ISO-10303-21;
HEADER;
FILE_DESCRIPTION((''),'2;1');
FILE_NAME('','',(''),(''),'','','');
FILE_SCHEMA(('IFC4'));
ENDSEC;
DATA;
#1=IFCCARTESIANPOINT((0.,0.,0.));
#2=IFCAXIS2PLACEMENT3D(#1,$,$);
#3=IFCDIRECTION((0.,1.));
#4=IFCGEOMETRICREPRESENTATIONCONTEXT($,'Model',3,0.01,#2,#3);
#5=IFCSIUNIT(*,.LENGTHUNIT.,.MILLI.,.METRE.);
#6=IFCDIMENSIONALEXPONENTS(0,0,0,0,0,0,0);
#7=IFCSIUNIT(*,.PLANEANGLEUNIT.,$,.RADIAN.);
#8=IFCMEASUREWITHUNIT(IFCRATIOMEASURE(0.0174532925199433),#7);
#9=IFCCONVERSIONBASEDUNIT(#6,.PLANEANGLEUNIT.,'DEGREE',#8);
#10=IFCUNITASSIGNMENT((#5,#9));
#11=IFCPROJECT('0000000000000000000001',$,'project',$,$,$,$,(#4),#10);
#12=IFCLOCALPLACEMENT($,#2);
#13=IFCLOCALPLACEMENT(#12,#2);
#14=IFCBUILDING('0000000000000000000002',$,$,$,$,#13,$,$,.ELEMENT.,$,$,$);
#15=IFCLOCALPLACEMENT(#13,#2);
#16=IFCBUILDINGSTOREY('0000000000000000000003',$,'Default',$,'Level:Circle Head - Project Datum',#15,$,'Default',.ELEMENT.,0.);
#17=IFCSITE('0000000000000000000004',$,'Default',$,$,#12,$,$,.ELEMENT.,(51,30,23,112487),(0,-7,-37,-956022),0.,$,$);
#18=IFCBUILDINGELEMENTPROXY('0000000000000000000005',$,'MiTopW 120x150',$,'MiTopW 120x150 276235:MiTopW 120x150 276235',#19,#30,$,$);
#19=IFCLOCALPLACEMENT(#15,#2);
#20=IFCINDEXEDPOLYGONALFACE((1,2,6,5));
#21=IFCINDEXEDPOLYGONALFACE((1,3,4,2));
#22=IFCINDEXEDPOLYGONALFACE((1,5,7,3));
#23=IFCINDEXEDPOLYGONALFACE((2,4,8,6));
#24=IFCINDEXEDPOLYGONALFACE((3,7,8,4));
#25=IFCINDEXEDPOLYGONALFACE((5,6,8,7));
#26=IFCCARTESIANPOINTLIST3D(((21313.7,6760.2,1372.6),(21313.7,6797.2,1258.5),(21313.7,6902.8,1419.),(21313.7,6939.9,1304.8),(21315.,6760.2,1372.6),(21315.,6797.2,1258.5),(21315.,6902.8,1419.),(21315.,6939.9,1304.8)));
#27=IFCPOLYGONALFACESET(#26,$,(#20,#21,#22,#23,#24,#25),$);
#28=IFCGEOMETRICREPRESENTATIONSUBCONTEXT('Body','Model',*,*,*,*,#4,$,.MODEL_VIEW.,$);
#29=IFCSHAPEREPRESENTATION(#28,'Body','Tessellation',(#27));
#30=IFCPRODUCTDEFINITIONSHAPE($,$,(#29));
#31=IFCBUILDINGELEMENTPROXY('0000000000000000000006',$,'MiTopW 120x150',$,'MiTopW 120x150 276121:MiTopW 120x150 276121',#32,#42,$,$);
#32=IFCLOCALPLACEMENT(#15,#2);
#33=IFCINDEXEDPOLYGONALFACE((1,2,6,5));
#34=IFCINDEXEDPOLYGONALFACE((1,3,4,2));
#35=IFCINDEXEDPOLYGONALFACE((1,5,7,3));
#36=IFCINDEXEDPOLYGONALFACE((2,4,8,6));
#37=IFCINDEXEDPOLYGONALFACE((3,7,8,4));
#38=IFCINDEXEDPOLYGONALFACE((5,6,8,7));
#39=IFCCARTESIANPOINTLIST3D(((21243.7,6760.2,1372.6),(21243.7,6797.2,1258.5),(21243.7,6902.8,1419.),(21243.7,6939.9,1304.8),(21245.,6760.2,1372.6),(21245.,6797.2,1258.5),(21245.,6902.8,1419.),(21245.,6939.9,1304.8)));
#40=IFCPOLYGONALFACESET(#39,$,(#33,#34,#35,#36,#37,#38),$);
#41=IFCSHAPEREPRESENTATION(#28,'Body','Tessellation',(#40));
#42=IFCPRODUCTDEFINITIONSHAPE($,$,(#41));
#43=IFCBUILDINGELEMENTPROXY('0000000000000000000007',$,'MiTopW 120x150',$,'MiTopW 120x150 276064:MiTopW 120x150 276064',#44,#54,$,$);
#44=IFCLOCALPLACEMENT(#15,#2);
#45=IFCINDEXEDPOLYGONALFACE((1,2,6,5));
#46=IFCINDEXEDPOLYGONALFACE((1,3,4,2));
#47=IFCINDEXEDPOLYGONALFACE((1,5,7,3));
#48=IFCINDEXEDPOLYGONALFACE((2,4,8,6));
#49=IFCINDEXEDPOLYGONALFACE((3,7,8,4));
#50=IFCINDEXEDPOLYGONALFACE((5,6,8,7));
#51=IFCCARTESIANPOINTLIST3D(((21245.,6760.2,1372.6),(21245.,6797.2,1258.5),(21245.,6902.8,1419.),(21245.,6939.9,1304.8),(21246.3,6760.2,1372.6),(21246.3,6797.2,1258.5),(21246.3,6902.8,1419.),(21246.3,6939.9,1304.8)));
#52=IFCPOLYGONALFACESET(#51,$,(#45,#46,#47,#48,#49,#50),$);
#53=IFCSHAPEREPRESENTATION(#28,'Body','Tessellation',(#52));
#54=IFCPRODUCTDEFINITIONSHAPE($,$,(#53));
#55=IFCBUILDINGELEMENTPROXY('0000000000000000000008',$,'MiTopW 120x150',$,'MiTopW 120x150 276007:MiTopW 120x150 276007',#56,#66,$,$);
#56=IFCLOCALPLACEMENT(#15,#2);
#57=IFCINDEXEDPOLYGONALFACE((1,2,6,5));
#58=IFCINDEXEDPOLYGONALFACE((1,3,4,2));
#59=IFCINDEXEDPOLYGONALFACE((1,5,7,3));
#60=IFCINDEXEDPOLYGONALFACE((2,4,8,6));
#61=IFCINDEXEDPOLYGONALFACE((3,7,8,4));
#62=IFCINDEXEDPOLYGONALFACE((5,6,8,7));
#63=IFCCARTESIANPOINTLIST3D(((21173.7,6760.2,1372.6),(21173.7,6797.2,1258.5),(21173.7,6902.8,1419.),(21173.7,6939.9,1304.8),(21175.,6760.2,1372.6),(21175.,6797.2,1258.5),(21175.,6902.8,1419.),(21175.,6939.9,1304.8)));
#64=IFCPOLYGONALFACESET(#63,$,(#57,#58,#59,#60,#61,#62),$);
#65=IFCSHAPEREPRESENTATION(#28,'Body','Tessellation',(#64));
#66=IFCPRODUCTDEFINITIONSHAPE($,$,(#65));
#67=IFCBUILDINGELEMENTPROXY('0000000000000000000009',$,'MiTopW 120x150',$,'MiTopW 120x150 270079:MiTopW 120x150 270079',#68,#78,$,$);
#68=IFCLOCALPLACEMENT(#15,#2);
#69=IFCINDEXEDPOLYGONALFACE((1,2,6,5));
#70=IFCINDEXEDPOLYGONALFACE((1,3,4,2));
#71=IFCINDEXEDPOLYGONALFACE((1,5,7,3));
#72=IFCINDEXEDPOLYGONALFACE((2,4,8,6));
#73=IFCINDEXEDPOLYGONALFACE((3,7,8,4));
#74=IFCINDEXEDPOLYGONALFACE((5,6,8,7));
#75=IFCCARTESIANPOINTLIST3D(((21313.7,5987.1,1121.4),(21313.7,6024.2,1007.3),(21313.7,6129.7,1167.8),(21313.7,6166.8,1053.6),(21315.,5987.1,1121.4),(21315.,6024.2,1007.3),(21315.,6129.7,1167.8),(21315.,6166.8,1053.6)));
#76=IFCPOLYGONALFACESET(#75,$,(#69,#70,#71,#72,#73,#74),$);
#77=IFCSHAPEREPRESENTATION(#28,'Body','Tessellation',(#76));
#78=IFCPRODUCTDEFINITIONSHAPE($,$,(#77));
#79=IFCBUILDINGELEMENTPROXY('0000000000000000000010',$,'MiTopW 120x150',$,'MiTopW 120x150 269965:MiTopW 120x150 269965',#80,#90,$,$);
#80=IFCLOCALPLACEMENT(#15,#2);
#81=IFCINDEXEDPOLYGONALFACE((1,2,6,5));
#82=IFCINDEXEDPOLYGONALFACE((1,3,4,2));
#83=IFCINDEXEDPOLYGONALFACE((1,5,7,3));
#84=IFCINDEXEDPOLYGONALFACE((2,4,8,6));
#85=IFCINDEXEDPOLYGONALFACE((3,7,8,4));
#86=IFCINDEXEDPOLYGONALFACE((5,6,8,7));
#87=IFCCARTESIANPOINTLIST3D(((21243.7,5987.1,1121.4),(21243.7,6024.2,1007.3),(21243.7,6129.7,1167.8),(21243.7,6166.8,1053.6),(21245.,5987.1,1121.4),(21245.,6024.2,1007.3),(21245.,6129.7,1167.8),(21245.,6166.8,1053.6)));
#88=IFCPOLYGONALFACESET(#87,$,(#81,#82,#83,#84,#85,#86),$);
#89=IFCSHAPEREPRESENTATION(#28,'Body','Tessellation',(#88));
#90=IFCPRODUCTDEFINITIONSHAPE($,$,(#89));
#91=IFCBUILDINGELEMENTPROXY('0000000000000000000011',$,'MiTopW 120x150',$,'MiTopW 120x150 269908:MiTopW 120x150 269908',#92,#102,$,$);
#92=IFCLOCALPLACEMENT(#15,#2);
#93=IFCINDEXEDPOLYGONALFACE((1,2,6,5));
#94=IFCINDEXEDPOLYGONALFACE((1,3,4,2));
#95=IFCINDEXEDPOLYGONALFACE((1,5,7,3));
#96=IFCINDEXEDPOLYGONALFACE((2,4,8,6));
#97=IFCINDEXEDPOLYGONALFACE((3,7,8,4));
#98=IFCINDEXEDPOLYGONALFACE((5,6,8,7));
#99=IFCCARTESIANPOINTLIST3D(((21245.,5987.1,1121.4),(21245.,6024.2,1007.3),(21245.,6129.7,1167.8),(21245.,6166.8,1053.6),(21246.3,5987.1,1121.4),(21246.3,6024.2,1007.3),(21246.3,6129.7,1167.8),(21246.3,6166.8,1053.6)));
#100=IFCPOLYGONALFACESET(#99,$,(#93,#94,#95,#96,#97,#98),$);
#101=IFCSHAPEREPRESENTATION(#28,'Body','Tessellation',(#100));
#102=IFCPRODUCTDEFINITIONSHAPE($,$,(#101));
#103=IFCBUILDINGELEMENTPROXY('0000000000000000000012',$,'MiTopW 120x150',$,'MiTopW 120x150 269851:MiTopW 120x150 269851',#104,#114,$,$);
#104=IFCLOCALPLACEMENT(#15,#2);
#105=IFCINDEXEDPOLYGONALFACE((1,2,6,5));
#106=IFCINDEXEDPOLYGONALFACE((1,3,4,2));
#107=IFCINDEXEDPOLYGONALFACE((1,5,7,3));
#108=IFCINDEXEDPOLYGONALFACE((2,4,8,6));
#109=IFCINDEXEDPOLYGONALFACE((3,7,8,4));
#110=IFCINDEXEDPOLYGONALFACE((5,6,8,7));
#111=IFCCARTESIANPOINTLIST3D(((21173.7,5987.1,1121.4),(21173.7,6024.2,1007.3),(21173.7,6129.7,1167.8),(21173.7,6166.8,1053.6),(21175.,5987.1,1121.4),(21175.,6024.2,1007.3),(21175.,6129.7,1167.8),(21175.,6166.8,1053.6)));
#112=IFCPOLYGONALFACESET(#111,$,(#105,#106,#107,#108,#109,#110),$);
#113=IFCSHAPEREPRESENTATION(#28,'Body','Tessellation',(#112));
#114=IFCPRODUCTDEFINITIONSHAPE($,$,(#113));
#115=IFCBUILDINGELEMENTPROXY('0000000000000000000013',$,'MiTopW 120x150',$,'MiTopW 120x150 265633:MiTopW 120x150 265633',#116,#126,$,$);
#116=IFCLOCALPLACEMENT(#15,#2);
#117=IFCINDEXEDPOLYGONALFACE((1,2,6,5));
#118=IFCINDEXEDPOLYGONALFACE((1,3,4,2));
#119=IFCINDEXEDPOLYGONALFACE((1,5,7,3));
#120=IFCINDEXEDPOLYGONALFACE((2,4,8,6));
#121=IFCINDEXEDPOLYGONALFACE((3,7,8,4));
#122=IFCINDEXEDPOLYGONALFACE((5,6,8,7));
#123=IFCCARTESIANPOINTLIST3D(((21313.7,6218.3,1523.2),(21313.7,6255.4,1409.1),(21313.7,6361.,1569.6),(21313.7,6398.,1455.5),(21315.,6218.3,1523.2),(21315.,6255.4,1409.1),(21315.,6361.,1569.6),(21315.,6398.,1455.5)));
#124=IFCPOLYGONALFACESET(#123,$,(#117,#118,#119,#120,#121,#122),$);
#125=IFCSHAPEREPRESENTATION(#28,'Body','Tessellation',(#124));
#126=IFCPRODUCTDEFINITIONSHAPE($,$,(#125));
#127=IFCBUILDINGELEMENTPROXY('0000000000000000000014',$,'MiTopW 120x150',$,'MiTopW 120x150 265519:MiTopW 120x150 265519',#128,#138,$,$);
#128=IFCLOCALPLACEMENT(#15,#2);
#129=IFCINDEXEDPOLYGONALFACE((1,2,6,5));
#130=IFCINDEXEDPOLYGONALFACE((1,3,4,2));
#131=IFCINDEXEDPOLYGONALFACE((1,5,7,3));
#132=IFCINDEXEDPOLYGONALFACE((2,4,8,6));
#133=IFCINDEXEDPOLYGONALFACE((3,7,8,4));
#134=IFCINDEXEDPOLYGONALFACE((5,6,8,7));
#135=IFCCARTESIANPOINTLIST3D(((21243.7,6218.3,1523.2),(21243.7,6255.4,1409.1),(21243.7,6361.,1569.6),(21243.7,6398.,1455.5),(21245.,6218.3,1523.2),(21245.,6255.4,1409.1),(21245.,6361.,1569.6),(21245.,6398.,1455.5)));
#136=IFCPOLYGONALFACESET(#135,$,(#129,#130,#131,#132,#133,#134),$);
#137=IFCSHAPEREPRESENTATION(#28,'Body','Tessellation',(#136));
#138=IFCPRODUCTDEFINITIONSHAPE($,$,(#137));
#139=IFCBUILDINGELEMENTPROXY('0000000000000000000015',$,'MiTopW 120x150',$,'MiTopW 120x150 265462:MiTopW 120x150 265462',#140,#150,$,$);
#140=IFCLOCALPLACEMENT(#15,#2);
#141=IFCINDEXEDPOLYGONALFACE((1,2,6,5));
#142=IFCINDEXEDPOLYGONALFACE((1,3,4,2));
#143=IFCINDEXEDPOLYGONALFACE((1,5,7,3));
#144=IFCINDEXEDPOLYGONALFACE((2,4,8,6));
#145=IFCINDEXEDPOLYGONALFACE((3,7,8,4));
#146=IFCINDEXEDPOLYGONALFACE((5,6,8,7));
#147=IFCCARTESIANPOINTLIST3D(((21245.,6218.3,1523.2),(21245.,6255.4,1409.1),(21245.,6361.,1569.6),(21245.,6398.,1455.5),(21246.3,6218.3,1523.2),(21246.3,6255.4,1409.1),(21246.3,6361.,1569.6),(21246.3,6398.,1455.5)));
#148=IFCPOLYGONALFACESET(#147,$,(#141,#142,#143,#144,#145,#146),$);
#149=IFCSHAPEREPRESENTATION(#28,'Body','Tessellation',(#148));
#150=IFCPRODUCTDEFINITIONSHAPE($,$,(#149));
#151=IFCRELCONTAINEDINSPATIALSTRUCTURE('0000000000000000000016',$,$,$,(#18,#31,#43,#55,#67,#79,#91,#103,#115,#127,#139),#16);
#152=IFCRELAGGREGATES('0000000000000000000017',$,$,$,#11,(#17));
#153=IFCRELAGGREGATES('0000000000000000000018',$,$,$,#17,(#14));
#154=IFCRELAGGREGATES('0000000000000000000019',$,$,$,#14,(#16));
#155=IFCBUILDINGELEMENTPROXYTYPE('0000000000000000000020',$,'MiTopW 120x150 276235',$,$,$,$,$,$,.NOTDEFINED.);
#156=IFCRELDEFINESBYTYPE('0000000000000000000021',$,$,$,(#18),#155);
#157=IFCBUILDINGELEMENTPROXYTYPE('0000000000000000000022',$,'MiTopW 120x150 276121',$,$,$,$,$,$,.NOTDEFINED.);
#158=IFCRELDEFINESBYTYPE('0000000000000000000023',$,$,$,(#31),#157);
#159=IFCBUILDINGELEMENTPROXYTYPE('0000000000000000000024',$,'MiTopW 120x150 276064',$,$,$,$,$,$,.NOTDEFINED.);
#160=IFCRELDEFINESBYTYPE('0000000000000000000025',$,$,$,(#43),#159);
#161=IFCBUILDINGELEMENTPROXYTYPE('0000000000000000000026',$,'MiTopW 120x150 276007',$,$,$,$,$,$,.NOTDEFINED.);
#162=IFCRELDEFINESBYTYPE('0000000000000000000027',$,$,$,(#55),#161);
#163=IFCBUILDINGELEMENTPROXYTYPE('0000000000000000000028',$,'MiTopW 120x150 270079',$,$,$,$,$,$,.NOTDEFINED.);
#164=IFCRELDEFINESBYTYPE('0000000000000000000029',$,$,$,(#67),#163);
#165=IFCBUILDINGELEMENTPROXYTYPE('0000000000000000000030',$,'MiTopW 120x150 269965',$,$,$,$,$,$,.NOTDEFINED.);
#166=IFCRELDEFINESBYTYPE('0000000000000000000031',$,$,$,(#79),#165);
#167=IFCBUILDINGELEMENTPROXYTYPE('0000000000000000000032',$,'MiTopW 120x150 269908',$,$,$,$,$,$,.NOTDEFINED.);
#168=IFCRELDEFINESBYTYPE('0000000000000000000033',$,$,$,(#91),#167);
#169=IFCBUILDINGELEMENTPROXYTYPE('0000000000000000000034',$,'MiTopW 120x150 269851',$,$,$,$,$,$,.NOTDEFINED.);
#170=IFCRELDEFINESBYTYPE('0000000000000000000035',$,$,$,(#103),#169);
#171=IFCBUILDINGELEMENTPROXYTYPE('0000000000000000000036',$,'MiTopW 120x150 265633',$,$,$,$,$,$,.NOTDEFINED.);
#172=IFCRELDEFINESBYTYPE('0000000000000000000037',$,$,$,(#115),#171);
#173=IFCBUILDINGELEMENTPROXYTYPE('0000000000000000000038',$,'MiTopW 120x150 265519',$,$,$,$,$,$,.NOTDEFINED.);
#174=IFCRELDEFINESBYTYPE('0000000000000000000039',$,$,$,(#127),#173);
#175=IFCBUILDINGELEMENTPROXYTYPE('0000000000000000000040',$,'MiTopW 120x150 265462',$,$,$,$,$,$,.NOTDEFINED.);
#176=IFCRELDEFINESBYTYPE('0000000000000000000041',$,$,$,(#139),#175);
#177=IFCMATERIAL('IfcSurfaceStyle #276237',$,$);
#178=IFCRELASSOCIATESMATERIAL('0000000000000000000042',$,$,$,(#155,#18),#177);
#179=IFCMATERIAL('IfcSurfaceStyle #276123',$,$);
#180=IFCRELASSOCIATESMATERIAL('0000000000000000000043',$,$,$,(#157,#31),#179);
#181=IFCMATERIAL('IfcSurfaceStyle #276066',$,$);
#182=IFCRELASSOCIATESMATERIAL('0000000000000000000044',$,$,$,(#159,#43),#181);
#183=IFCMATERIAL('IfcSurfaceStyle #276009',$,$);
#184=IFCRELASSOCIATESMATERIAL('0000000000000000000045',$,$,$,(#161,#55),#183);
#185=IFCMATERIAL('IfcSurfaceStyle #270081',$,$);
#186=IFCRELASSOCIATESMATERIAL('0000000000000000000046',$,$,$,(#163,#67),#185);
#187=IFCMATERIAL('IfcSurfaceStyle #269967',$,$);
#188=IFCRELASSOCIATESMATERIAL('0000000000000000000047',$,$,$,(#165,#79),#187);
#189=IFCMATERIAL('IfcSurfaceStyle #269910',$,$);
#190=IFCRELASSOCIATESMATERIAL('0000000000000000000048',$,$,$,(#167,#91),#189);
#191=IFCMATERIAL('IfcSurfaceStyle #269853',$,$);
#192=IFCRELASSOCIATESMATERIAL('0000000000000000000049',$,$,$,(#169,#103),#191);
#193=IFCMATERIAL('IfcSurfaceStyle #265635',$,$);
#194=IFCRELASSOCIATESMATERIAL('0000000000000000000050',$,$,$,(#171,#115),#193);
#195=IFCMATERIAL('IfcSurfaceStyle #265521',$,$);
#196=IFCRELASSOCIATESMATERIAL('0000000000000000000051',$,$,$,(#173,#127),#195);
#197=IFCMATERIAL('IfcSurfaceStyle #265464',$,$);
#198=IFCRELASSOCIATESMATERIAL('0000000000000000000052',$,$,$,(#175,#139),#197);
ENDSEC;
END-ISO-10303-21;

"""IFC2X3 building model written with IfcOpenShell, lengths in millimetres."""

from ifc_helpers import new_model, entity, si_unit, converted_unit, direction, frame, origin, place, context, subcontext, project, spatial, polyline, outline, extrude, source, transform, mapped, material, type_object, type_shapes, element, save


model = new_model("IFC2X3")

# Units and contexts
model_context = context("Model", 3, precision=0.01, world=origin(), true_north=direction((0.0, 1.0)))
body_context = subcontext(model_context, "Body", "Model", "MODEL_VIEW")
ifc_project = project(units=[si_unit("LENGTHUNIT", "METRE", prefix="MILLI"), converted_unit("PLANEANGLEUNIT", "DEGREE", entity("IfcRatioMeasure", 0.0174532925199433), si_unit("PLANEANGLEUNIT", "RADIAN"), dimensions=[0, 0, 0, 0, 0, 0, 0])], contexts=[model_context])

# Site, building, storey
site_placement = place(None, origin())
site = spatial("IfcSite", under=ifc_project, at=site_placement, Name="Default", CompositionType="ELEMENT", RefLatitude=(51, 30, 23, 112487), RefLongitude=(0, -7, -37, -956022), RefElevation=0.0)
building_placement = place(site_placement, origin())
building = spatial("IfcBuilding", under=site, at=building_placement, CompositionType="ELEMENT")
storey_placement = place(building_placement, origin())
storey = spatial("IfcBuildingStorey", under=building, at=storey_placement, Name="Default", ObjectType="Level:Circle Head - Project Datum", LongName="Default", CompositionType="ELEMENT", Elevation=0.0)

# Building element proxies
ifc_material_1 = material(Name="IfcSurfaceStyle #276237")
building_element_proxy_type_1 = type_object("IfcBuildingElementProxyType", Name="MiTopW 120x150 276235", PredefinedType="NOTDEFINED", material=ifc_material_1)
shared_shape_1 = source(origin(), body_context, "Body", "SweptSolid", [
    extrude(outline(polyline([(-75.0, -60.0), (75.0, -60.0), (75.0, 60.0), (-75.0, 60.0), (-75.0, -60.0)])), frame((75.0, 60.0, 0.0), z_axis=(0.0, 0.0, 1.0), x_axis=(-1.0, 0.0, 0.0)), (0.0, 0.0, 1.0), 1.3),
])
type_shapes(building_element_proxy_type_1, [shared_shape_1])
proxy_1_placement = place(building_placement, frame((21315.0, 6760.2, 1372.6), z_axis=(-1.0, 0.0, 0.0), x_axis=(0.0, 0.951057, 0.309017)))
element("IfcBuildingElementProxy", 1, at=proxy_1_placement, inside=storey, type_object=building_element_proxy_type_1, material=ifc_material_1, Name="MiTopW 120x150", ObjectType="MiTopW 120x150 276235:MiTopW 120x150 276235", context=body_context, shape_type="MappedRepresentation", body=[
    mapped(shared_shape_1, transform((0.0, 0.0, 0.0), scale=1.0)),
])
ifc_material_2 = material(Name="IfcSurfaceStyle #276123")
building_element_proxy_type_2 = type_object("IfcBuildingElementProxyType", Name="MiTopW 120x150 276121", PredefinedType="NOTDEFINED", material=ifc_material_2)
shared_shape_2 = source(origin(), body_context, "Body", "SweptSolid", [
    extrude(outline(polyline([(-75.0, -60.0), (75.0, -60.0), (75.0, 60.0), (-75.0, 60.0), (-75.0, -60.0)])), frame((75.0, 60.0, 0.0), z_axis=(0.0, 0.0, 1.0), x_axis=(-1.0, 0.0, 0.0)), (0.0, 0.0, 1.0), 1.3),
])
type_shapes(building_element_proxy_type_2, [shared_shape_2])
proxy_2_placement = place(building_placement, frame((21245.0, 6760.2, 1372.6), z_axis=(-1.0, 0.0, 0.0), x_axis=(0.0, 0.951057, 0.309017)))
element("IfcBuildingElementProxy", 2, at=proxy_2_placement, inside=storey, type_object=building_element_proxy_type_2, material=ifc_material_2, Name="MiTopW 120x150", ObjectType="MiTopW 120x150 276121:MiTopW 120x150 276121", context=body_context, shape_type="MappedRepresentation", body=[
    mapped(shared_shape_2, transform((0.0, 0.0, 0.0), scale=1.0)),
])
ifc_material_3 = material(Name="IfcSurfaceStyle #276066")
building_element_proxy_type_3 = type_object("IfcBuildingElementProxyType", Name="MiTopW 120x150 276064", PredefinedType="NOTDEFINED", material=ifc_material_3)
shared_shape_3 = source(origin(), body_context, "Body", "SweptSolid", [
    extrude(outline(polyline([(-75.0, -60.0), (75.0, -60.0), (75.0, 60.0), (-75.0, 60.0), (-75.0, -60.0)])), frame((75.0, 60.0, 0.0), z_axis=(0.0, 0.0, 1.0), x_axis=(-1.0, 0.0, 0.0)), (0.0, 0.0, 1.0), 1.3),
])
type_shapes(building_element_proxy_type_3, [shared_shape_3])
proxy_3_placement = place(building_placement, frame((21246.3, 6760.2, 1372.6), z_axis=(-1.0, 0.0, 0.0), x_axis=(0.0, 0.951057, 0.309017)))
element("IfcBuildingElementProxy", 3, at=proxy_3_placement, inside=storey, type_object=building_element_proxy_type_3, material=ifc_material_3, Name="MiTopW 120x150", ObjectType="MiTopW 120x150 276064:MiTopW 120x150 276064", context=body_context, shape_type="MappedRepresentation", body=[
    mapped(shared_shape_3, transform((0.0, 0.0, 0.0), scale=1.0)),
])
ifc_material_4 = material(Name="IfcSurfaceStyle #276009")
building_element_proxy_type_4 = type_object("IfcBuildingElementProxyType", Name="MiTopW 120x150 276007", PredefinedType="NOTDEFINED", material=ifc_material_4)
shared_shape_4 = source(origin(), body_context, "Body", "SweptSolid", [
    extrude(outline(polyline([(-75.0, -60.0), (75.0, -60.0), (75.0, 60.0), (-75.0, 60.0), (-75.0, -60.0)])), frame((75.0, 60.0, 0.0), z_axis=(0.0, 0.0, 1.0), x_axis=(-1.0, 0.0, 0.0)), (0.0, 0.0, 1.0), 1.3),
])
type_shapes(building_element_proxy_type_4, [shared_shape_4])
proxy_4_placement = place(building_placement, frame((21175.0, 6760.2, 1372.6), z_axis=(-1.0, 0.0, 0.0), x_axis=(0.0, 0.951057, 0.309017)))
element("IfcBuildingElementProxy", 4, at=proxy_4_placement, inside=storey, type_object=building_element_proxy_type_4, material=ifc_material_4, Name="MiTopW 120x150", ObjectType="MiTopW 120x150 276007:MiTopW 120x150 276007", context=body_context, shape_type="MappedRepresentation", body=[
    mapped(shared_shape_4, transform((0.0, 0.0, 0.0), scale=1.0)),
])
ifc_material_5 = material(Name="IfcSurfaceStyle #270081")
building_element_proxy_type_5 = type_object("IfcBuildingElementProxyType", Name="MiTopW 120x150 270079", PredefinedType="NOTDEFINED", material=ifc_material_5)
shared_shape_5 = source(origin(), body_context, "Body", "SweptSolid", [
    extrude(outline(polyline([(-75.0, -60.0), (75.0, -60.0), (75.0, 60.0), (-75.0, 60.0), (-75.0, -60.0)])), frame((75.0, 60.0, 0.0), z_axis=(0.0, 0.0, 1.0), x_axis=(-1.0, 0.0, 0.0)), (0.0, 0.0, 1.0), 1.3),
])
type_shapes(building_element_proxy_type_5, [shared_shape_5])
proxy_5_placement = place(building_placement, frame((21315.0, 5987.1, 1121.4), z_axis=(-1.0, 0.0, 0.0), x_axis=(0.0, 0.951057, 0.309017)))
element("IfcBuildingElementProxy", 5, at=proxy_5_placement, inside=storey, type_object=building_element_proxy_type_5, material=ifc_material_5, Name="MiTopW 120x150", ObjectType="MiTopW 120x150 270079:MiTopW 120x150 270079", context=body_context, shape_type="MappedRepresentation", body=[
    mapped(shared_shape_5, transform((0.0, 0.0, 0.0), scale=1.0)),
])
ifc_material_6 = material(Name="IfcSurfaceStyle #269967")
building_element_proxy_type_6 = type_object("IfcBuildingElementProxyType", Name="MiTopW 120x150 269965", PredefinedType="NOTDEFINED", material=ifc_material_6)
shared_shape_6 = source(origin(), body_context, "Body", "SweptSolid", [
    extrude(outline(polyline([(-75.0, -60.0), (75.0, -60.0), (75.0, 60.0), (-75.0, 60.0), (-75.0, -60.0)])), frame((75.0, 60.0, 0.0), z_axis=(0.0, 0.0, 1.0), x_axis=(-1.0, 0.0, 0.0)), (0.0, 0.0, 1.0), 1.3),
])
type_shapes(building_element_proxy_type_6, [shared_shape_6])
proxy_6_placement = place(building_placement, frame((21245.0, 5987.1, 1121.4), z_axis=(-1.0, 0.0, 0.0), x_axis=(0.0, 0.951057, 0.309017)))
element("IfcBuildingElementProxy", 6, at=proxy_6_placement, inside=storey, type_object=building_element_proxy_type_6, material=ifc_material_6, Name="MiTopW 120x150", ObjectType="MiTopW 120x150 269965:MiTopW 120x150 269965", context=body_context, shape_type="MappedRepresentation", body=[
    mapped(shared_shape_6, transform((0.0, 0.0, 0.0), scale=1.0)),
])
ifc_material_7 = material(Name="IfcSurfaceStyle #269910")
building_element_proxy_type_7 = type_object("IfcBuildingElementProxyType", Name="MiTopW 120x150 269908", PredefinedType="NOTDEFINED", material=ifc_material_7)
shared_shape_7 = source(origin(), body_context, "Body", "SweptSolid", [
    extrude(outline(polyline([(-75.0, -60.0), (75.0, -60.0), (75.0, 60.0), (-75.0, 60.0), (-75.0, -60.0)])), frame((75.0, 60.0, 0.0), z_axis=(0.0, 0.0, 1.0), x_axis=(-1.0, 0.0, 0.0)), (0.0, 0.0, 1.0), 1.3),
])
type_shapes(building_element_proxy_type_7, [shared_shape_7])
proxy_7_placement = place(building_placement, frame((21246.3, 5987.1, 1121.4), z_axis=(-1.0, 0.0, 0.0), x_axis=(0.0, 0.951057, 0.309017)))
element("IfcBuildingElementProxy", 7, at=proxy_7_placement, inside=storey, type_object=building_element_proxy_type_7, material=ifc_material_7, Name="MiTopW 120x150", ObjectType="MiTopW 120x150 269908:MiTopW 120x150 269908", context=body_context, shape_type="MappedRepresentation", body=[
    mapped(shared_shape_7, transform((0.0, 0.0, 0.0), scale=1.0)),
])
ifc_material_8 = material(Name="IfcSurfaceStyle #269853")
building_element_proxy_type_8 = type_object("IfcBuildingElementProxyType", Name="MiTopW 120x150 269851", PredefinedType="NOTDEFINED", material=ifc_material_8)
shared_shape_8 = source(origin(), body_context, "Body", "SweptSolid", [
    extrude(outline(polyline([(-75.0, -60.0), (75.0, -60.0), (75.0, 60.0), (-75.0, 60.0), (-75.0, -60.0)])), frame((75.0, 60.0, 0.0), z_axis=(0.0, 0.0, 1.0), x_axis=(-1.0, 0.0, 0.0)), (0.0, 0.0, 1.0), 1.3),
])
type_shapes(building_element_proxy_type_8, [shared_shape_8])
proxy_8_placement = place(building_placement, frame((21175.0, 5987.1, 1121.4), z_axis=(-1.0, 0.0, 0.0), x_axis=(0.0, 0.951057, 0.309017)))
element("IfcBuildingElementProxy", 8, at=proxy_8_placement, inside=storey, type_object=building_element_proxy_type_8, material=ifc_material_8, Name="MiTopW 120x150", ObjectType="MiTopW 120x150 269851:MiTopW 120x150 269851", context=body_context, shape_type="MappedRepresentation", body=[
    mapped(shared_shape_8, transform((0.0, 0.0, 0.0), scale=1.0)),
])
ifc_material_9 = material(Name="IfcSurfaceStyle #265635")
building_element_proxy_type_9 = type_object("IfcBuildingElementProxyType", Name="MiTopW 120x150 265633", PredefinedType="NOTDEFINED", material=ifc_material_9)
shared_shape_9 = source(origin(), body_context, "Body", "SweptSolid", [
    extrude(outline(polyline([(-75.0, -60.0), (75.0, -60.0), (75.0, 60.0), (-75.0, 60.0), (-75.0, -60.0)])), frame((75.0, 60.0, 0.0), z_axis=(0.0, 0.0, 1.0), x_axis=(-1.0, 0.0, 0.0)), (0.0, 0.0, 1.0), 1.3),
])
type_shapes(building_element_proxy_type_9, [shared_shape_9])
proxy_9_placement = place(building_placement, frame((21315.0, 6218.3, 1523.2), z_axis=(-1.0, 0.0, 0.0), x_axis=(0.0, 0.951057, 0.309017)))
element("IfcBuildingElementProxy", 9, at=proxy_9_placement, inside=storey, type_object=building_element_proxy_type_9, material=ifc_material_9, Name="MiTopW 120x150", ObjectType="MiTopW 120x150 265633:MiTopW 120x150 265633", context=body_context, shape_type="MappedRepresentation", body=[
    mapped(shared_shape_9, transform((0.0, 0.0, 0.0), scale=1.0)),
])
ifc_material_10 = material(Name="IfcSurfaceStyle #265521")
building_element_proxy_type_10 = type_object("IfcBuildingElementProxyType", Name="MiTopW 120x150 265519", PredefinedType="NOTDEFINED", material=ifc_material_10)
shared_shape_10 = source(origin(), body_context, "Body", "SweptSolid", [
    extrude(outline(polyline([(-75.0, -60.0), (75.0, -60.0), (75.0, 60.0), (-75.0, 60.0), (-75.0, -60.0)])), frame((75.0, 60.0, 0.0), z_axis=(0.0, 0.0, 1.0), x_axis=(-1.0, 0.0, 0.0)), (0.0, 0.0, 1.0), 1.3),
])
type_shapes(building_element_proxy_type_10, [shared_shape_10])
proxy_10_placement = place(building_placement, frame((21245.0, 6218.3, 1523.2), z_axis=(-1.0, 0.0, 0.0), x_axis=(0.0, 0.951057, 0.309017)))
element("IfcBuildingElementProxy", 10, at=proxy_10_placement, inside=storey, type_object=building_element_proxy_type_10, material=ifc_material_10, Name="MiTopW 120x150", ObjectType="MiTopW 120x150 265519:MiTopW 120x150 265519", context=body_context, shape_type="MappedRepresentation", body=[
    mapped(shared_shape_10, transform((0.0, 0.0, 0.0), scale=1.0)),
])
ifc_material_11 = material(Name="IfcSurfaceStyle #265464")
building_element_proxy_type_11 = type_object("IfcBuildingElementProxyType", Name="MiTopW 120x150 265462", PredefinedType="NOTDEFINED", material=ifc_material_11)
shared_shape_11 = source(origin(), body_context, "Body", "SweptSolid", [
    extrude(outline(polyline([(-75.0, -60.0), (75.0, -60.0), (75.0, 60.0), (-75.0, 60.0), (-75.0, -60.0)])), frame((75.0, 60.0, 0.0), z_axis=(0.0, 0.0, 1.0), x_axis=(-1.0, 0.0, 0.0)), (0.0, 0.0, 1.0), 1.3),
])
type_shapes(building_element_proxy_type_11, [shared_shape_11])
proxy_11_placement = place(building_placement, frame((21246.3, 6218.3, 1523.2), z_axis=(-1.0, 0.0, 0.0), x_axis=(0.0, 0.951057, 0.309017)))
element("IfcBuildingElementProxy", 11, at=proxy_11_placement, inside=storey, type_object=building_element_proxy_type_11, material=ifc_material_11, Name="MiTopW 120x150", ObjectType="MiTopW 120x150 265462:MiTopW 120x150 265462", context=body_context, shape_type="MappedRepresentation", body=[
    mapped(shared_shape_11, transform((0.0, 0.0, 0.0), scale=1.0)),
])

save(model, "model.ifc")
